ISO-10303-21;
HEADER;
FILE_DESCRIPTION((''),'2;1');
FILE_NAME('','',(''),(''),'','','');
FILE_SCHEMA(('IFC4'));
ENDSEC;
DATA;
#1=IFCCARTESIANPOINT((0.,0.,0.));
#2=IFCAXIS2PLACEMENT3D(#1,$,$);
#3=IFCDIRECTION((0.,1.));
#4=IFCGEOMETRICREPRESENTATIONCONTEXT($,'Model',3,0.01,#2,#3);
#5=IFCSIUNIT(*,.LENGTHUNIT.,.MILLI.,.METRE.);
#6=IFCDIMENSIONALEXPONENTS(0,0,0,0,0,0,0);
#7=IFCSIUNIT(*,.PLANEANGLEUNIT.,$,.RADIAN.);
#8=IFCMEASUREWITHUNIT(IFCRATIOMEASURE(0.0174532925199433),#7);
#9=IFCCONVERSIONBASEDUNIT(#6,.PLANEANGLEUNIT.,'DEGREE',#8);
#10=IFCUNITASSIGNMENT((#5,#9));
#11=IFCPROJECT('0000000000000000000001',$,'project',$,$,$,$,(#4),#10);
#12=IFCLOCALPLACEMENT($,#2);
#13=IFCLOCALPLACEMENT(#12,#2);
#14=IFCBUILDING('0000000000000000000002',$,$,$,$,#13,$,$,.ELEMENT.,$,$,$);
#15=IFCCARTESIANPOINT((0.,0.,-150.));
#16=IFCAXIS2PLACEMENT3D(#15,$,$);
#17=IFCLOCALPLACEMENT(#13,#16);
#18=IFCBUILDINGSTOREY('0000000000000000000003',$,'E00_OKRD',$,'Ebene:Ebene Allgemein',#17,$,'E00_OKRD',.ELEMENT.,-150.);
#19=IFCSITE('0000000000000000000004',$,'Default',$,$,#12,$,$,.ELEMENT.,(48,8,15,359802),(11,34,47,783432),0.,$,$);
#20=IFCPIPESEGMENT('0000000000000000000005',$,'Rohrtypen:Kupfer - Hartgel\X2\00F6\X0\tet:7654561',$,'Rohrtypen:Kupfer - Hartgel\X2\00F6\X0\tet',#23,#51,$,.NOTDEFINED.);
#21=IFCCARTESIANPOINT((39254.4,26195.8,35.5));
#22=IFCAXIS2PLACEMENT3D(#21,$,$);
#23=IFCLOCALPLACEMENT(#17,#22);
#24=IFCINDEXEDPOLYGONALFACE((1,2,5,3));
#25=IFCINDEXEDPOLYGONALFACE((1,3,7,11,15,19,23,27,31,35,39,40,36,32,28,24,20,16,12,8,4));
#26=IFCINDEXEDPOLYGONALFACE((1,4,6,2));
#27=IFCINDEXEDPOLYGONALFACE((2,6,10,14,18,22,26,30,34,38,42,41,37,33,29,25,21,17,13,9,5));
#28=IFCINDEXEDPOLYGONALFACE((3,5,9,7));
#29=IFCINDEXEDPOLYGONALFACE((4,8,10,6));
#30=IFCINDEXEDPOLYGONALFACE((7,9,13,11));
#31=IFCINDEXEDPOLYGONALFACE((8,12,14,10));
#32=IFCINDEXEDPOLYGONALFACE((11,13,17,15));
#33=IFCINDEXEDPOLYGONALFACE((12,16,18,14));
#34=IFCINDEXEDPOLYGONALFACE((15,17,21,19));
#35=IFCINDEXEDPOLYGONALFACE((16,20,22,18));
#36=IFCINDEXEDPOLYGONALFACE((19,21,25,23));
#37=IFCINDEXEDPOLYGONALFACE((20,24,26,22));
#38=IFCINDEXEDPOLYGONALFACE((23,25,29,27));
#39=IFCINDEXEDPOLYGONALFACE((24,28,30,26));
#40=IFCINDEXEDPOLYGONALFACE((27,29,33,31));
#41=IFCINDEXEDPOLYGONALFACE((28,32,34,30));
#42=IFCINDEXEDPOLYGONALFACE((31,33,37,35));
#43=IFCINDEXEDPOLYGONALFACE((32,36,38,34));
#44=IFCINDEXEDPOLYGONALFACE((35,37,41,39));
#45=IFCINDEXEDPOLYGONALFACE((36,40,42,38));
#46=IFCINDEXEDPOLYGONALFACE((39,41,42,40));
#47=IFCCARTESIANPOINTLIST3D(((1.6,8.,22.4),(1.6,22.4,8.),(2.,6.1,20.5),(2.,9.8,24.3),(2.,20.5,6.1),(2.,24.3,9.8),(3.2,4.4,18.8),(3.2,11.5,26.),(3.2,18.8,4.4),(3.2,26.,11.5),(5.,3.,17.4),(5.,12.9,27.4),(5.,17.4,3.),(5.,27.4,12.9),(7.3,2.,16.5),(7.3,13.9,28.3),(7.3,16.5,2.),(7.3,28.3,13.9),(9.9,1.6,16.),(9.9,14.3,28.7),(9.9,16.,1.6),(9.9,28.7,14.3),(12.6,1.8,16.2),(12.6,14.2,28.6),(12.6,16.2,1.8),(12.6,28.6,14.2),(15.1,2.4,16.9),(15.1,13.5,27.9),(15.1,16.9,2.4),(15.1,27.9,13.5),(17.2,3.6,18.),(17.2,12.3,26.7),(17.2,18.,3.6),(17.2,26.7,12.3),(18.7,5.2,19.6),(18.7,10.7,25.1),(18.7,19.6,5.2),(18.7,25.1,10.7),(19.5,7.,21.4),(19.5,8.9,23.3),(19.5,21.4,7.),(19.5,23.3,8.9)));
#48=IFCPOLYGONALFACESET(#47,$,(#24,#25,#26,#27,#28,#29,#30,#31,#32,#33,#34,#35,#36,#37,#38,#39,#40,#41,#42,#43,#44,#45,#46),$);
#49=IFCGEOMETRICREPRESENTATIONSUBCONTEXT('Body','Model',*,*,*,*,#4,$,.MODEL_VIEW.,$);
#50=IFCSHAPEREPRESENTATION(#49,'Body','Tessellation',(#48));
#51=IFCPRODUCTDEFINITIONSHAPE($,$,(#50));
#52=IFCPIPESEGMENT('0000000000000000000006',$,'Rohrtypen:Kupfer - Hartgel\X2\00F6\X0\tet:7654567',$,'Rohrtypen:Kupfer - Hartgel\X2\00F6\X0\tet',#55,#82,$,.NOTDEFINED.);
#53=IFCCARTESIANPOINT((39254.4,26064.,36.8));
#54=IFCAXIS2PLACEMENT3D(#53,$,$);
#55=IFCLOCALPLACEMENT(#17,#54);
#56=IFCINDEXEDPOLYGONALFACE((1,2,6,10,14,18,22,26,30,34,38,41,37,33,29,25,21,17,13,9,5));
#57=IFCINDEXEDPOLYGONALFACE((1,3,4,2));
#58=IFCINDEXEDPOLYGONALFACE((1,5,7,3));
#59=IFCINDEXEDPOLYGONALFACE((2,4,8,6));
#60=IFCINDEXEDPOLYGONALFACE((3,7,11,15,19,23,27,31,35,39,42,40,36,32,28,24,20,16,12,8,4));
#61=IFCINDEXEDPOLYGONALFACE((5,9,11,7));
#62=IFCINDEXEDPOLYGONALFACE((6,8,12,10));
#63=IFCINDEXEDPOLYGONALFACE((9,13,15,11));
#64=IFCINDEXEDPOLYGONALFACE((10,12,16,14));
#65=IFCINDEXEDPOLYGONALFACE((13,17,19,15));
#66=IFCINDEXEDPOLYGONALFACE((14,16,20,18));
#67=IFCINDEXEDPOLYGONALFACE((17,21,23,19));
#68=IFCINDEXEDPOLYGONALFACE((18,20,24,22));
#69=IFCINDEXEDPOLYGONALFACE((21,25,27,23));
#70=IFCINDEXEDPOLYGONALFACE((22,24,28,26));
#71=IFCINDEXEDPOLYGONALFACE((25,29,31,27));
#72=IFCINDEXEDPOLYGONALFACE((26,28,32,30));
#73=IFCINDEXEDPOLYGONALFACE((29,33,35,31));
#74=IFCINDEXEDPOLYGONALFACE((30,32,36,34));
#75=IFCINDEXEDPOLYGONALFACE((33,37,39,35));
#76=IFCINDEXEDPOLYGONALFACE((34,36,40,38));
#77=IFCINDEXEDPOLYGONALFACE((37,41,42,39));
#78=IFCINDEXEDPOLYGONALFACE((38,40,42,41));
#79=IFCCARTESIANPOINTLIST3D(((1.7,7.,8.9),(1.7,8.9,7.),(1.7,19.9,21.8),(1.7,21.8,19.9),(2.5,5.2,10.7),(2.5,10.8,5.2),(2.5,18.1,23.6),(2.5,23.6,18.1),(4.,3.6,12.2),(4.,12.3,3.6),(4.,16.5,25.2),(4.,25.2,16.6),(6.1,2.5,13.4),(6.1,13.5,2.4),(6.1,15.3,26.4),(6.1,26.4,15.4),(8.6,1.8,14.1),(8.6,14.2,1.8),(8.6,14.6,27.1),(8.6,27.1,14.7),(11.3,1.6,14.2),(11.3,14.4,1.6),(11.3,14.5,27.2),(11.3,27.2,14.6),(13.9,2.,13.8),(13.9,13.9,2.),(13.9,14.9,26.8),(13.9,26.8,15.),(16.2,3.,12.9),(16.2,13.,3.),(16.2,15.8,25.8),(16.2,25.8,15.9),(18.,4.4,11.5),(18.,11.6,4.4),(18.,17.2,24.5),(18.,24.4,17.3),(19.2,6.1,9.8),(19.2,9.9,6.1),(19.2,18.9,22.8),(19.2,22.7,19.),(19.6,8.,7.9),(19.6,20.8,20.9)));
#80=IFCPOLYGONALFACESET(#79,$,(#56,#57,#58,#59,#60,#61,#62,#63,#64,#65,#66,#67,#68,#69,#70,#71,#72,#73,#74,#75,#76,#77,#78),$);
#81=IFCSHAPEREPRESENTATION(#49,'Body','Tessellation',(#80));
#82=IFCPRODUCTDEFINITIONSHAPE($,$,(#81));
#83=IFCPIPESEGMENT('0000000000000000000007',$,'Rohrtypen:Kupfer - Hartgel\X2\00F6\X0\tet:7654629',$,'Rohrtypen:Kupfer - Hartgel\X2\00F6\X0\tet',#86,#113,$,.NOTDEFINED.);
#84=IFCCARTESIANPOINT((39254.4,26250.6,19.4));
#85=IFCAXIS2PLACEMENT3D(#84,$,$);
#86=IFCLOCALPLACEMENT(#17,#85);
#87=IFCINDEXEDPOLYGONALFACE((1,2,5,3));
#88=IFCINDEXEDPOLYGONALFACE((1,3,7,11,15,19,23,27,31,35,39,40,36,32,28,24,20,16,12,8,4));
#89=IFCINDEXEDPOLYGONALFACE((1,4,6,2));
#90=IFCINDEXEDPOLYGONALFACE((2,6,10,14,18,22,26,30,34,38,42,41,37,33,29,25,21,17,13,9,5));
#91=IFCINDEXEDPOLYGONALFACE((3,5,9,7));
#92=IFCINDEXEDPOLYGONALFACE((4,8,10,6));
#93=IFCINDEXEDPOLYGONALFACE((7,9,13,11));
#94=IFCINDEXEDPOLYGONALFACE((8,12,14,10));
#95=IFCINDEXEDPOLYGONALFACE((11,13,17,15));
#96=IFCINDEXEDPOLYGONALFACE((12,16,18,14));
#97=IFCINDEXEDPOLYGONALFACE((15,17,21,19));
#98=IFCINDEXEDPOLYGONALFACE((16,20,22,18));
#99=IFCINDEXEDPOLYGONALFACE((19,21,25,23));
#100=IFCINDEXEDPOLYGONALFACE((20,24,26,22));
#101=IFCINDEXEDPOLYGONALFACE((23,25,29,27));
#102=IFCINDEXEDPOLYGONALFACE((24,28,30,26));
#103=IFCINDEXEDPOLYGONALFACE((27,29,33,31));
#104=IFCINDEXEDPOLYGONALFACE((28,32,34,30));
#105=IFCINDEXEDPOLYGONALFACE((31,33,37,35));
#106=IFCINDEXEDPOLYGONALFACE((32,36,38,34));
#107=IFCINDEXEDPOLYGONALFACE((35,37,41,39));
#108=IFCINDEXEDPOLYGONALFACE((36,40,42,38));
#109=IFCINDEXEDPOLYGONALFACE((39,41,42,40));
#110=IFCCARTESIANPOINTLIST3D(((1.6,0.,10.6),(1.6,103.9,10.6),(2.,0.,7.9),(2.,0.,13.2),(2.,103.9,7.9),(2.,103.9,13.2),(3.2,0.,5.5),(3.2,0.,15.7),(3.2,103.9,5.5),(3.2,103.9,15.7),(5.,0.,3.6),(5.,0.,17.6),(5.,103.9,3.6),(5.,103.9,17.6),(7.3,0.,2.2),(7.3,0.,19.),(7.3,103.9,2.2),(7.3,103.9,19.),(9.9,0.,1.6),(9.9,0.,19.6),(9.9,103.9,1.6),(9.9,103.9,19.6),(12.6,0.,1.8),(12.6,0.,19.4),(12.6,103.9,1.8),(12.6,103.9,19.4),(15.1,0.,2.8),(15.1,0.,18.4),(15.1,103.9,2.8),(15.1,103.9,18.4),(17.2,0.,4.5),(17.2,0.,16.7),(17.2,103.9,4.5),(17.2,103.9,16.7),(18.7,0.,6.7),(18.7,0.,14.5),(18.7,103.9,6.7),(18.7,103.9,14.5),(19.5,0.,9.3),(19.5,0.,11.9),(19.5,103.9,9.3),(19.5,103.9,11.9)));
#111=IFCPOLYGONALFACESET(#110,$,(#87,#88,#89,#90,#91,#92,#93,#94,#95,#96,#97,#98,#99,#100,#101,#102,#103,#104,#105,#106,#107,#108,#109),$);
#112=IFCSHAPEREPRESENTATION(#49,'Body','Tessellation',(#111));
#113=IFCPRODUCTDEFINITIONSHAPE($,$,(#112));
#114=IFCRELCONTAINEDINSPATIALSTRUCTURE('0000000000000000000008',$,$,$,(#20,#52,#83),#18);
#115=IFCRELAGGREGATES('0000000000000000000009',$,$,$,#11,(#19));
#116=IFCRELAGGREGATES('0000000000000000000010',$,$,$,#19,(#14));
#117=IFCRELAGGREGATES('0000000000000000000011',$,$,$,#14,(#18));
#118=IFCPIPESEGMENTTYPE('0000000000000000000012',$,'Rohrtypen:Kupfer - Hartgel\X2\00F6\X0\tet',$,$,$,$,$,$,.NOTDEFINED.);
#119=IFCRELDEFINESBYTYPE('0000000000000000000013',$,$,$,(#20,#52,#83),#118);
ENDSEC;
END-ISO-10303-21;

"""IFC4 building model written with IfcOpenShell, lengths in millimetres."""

from ifc_helpers import new_model, entity, si_unit, converted_unit, direction, frame, origin, origin_2d_with_axis, place, context, subcontext, project, spatial, circle, extrude, type_object, element, save


model = new_model("IFC4")

# Units and contexts
model_context = context("Model", 3, precision=0.01, world=origin(), true_north=direction((0.0, 1.0)))
body_context = subcontext(model_context, "Body", "Model", "MODEL_VIEW")
ifc_project = project(units=[si_unit("LENGTHUNIT", "METRE", prefix="MILLI"), converted_unit("PLANEANGLEUNIT", "DEGREE", entity("IfcRatioMeasure", 0.0174532925199433), si_unit("PLANEANGLEUNIT", "RADIAN"), dimensions=[0, 0, 0, 0, 0, 0, 0])], contexts=[model_context])

# Site, building, storey
site_placement = place(None, origin())
site = spatial("IfcSite", under=ifc_project, at=site_placement, Name="Default", CompositionType="ELEMENT", RefLatitude=(48, 8, 15, 359802), RefLongitude=(11, 34, 47, 783432), RefElevation=0.0)
building_placement = place(site_placement, origin())
building = spatial("IfcBuilding", under=site, at=building_placement, CompositionType="ELEMENT")
storey_placement = place(building_placement, frame((0.0, 0.0, -150.0)))
storey = spatial("IfcBuildingStorey", under=building, at=storey_placement, Name="E00_OKRD", ObjectType="Ebene:Ebene Allgemein", LongName="E00_OKRD", CompositionType="ELEMENT", Elevation=-150.0)

# Pipe segments
pipe_segment_type = type_object("IfcPipeSegmentType", Name="Rohrtypen:Kupfer - Hartgelötet", PredefinedType="NOTDEFINED")
pipe_segment_1_placement = place(storey_placement, frame((39254.4, 26195.8, 35.5)))
element("IfcPipeSegment", 1, at=pipe_segment_1_placement, inside=storey, type_object=pipe_segment_type, Name="Rohrtypen:Kupfer - Hartgelötet:7654561", ObjectType="Rohrtypen:Kupfer - Hartgelötet", PredefinedType="NOTDEFINED", context=body_context, shape_type="SweptSolid", body=[
    extrude(circle(Radius=9.0, at=origin_2d_with_axis()), frame((10.6, 8.0, 22.4), z_axis=(0.0, 0.707107, -0.707107), x_axis=(-1.0, 0.0, 0.0)), (0.0, 0.0, 1.0), 20.4),
])
pipe_segment_2_placement = place(storey_placement, frame((39254.4, 26064.0, 36.8)))
element("IfcPipeSegment", 2, at=pipe_segment_2_placement, inside=storey, type_object=pipe_segment_type, Name="Rohrtypen:Kupfer - Hartgelötet:7654567", ObjectType="Rohrtypen:Kupfer - Hartgelötet", PredefinedType="NOTDEFINED", context=body_context, shape_type="SweptSolid", body=[
    extrude(circle(Radius=9.0, at=origin_2d_with_axis()), frame((10.6, 8.0, 7.9), z_axis=(0.0, 0.70394, 0.71026), x_axis=(1.0, 0.0, 0.0)), (0.0, 0.0, 1.0), 18.2),
])
pipe_segment_3_placement = place(storey_placement, frame((39254.4, 26250.6, 19.4)))
element("IfcPipeSegment", 3, at=pipe_segment_3_placement, inside=storey, type_object=pipe_segment_type, Name="Rohrtypen:Kupfer - Hartgelötet:7654629", ObjectType="Rohrtypen:Kupfer - Hartgelötet", PredefinedType="NOTDEFINED", context=body_context, shape_type="SweptSolid", body=[
    extrude(circle(Radius=9.0, at=origin_2d_with_axis()), frame((10.6, 0.0, 10.6), z_axis=(0.0, 1.0, 0.0), x_axis=(-1.0, 0.0, 0.0)), (0.0, 0.0, 1.0), 103.9),
])

save(model, "model.ifc")
